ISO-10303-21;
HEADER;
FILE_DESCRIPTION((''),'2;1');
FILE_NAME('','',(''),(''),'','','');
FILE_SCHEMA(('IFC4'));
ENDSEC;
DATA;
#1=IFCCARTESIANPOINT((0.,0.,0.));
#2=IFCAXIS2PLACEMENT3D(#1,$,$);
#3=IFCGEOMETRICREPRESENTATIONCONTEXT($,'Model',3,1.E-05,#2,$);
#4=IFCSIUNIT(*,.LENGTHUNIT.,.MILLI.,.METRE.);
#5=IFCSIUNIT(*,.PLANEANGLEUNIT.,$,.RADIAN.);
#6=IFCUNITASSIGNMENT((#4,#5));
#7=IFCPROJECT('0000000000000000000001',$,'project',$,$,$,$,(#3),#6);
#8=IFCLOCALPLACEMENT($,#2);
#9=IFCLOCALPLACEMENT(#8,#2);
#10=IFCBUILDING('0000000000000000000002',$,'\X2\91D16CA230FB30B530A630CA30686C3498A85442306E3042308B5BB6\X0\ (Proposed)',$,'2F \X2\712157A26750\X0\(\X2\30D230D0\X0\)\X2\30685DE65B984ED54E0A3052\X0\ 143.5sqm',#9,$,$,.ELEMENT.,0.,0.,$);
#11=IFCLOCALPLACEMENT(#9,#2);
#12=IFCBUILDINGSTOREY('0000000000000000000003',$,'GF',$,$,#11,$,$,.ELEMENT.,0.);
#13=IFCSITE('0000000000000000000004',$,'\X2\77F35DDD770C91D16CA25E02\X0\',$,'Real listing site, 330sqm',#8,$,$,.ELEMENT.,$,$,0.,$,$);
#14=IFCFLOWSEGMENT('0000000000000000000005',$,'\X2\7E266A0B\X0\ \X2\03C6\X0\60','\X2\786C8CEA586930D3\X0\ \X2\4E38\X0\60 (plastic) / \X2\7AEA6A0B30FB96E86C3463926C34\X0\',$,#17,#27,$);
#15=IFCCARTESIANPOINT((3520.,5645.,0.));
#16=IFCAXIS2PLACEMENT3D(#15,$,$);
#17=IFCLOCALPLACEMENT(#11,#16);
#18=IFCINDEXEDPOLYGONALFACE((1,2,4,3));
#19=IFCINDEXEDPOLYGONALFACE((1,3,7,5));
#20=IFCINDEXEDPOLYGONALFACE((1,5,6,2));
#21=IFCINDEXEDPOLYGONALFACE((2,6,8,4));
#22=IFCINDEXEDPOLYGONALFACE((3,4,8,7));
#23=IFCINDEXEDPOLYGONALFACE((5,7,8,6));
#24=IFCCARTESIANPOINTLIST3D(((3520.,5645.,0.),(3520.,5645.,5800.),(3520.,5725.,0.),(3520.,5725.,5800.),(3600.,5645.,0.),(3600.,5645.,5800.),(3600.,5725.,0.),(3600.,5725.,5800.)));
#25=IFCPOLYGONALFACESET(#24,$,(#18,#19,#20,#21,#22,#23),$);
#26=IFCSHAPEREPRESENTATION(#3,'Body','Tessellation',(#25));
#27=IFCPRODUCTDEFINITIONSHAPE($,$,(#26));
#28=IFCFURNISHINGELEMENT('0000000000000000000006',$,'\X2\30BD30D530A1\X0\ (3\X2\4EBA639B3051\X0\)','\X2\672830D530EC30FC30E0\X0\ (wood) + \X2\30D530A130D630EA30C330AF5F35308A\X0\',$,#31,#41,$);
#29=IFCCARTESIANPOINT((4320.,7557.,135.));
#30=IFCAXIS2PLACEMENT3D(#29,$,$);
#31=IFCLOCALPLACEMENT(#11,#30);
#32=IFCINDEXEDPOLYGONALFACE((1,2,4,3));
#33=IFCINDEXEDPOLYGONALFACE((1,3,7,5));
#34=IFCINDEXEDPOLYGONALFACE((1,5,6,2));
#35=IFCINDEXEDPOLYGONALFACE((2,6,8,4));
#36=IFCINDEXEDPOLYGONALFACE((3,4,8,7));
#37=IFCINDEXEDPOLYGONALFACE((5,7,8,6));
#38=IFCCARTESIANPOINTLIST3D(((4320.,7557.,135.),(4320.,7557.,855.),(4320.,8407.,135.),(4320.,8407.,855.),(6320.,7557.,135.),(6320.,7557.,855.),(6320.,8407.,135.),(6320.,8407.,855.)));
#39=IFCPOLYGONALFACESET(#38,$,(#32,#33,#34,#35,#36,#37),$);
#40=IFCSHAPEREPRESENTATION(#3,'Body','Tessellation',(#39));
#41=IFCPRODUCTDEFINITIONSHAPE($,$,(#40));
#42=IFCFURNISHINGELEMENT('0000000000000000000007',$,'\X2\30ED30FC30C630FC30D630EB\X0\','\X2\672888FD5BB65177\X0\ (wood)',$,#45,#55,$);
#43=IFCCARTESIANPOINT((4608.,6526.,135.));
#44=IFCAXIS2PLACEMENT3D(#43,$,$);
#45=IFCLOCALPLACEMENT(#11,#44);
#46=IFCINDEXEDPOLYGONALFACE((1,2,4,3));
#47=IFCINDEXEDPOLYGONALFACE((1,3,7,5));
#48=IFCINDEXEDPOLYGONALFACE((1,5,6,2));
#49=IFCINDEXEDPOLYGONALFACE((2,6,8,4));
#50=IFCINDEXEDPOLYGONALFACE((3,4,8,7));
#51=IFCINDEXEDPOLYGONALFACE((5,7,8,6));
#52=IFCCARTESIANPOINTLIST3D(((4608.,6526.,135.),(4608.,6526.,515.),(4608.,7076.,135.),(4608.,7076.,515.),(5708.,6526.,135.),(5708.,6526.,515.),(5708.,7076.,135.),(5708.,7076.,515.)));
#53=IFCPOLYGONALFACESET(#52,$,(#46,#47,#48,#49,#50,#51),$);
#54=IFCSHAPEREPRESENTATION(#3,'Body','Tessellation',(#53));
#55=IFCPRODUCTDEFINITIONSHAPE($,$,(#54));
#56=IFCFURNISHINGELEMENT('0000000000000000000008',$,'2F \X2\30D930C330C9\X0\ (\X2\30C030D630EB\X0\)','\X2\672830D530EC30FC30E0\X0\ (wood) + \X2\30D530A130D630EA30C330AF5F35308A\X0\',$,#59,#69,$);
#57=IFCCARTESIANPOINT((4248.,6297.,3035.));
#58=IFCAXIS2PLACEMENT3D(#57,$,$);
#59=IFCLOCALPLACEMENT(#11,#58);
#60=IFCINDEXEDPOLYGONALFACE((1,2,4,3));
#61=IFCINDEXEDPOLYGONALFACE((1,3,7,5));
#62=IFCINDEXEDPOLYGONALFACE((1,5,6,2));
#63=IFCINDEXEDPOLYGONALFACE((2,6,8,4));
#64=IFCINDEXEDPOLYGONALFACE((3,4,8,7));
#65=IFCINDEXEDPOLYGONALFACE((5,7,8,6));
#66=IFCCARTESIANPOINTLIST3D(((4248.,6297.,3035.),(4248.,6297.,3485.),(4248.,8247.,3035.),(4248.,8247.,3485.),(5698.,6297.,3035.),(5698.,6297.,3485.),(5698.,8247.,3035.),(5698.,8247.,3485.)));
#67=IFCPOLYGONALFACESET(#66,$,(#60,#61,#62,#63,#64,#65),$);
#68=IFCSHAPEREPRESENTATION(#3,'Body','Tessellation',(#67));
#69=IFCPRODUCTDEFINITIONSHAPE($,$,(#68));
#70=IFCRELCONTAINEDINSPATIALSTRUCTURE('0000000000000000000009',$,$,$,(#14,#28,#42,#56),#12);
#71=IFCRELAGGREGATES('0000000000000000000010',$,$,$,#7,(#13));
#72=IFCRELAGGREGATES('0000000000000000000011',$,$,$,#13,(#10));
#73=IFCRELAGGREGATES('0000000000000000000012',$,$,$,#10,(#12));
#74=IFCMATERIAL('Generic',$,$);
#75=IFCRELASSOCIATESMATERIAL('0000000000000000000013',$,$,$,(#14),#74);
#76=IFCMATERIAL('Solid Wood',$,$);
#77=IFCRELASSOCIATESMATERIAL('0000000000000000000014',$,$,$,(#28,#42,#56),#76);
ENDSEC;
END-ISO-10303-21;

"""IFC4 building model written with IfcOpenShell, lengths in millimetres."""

from ifc_helpers import new_model, si_unit, frame, frame_2d, origin, place, context, project, spatial, rectangle, extrude, material, element, save


model = new_model("IFC4")

# Units and contexts
model_context = context("Model", 3, precision=1e-05, world=origin())
ifc_project = project(units=[si_unit("LENGTHUNIT", "METRE", prefix="MILLI"), si_unit("PLANEANGLEUNIT", "RADIAN")], contexts=[model_context])

# Site, building, storey
site_placement = place(None, origin())
site = spatial("IfcSite", under=ifc_project, at=site_placement, Name="石川県金沢市", ObjectType="Real listing site, 330sqm", CompositionType="ELEMENT", RefElevation=0.0)
building_placement = place(site_placement, origin())
building = spatial("IfcBuilding", under=site, at=building_placement, Name="金沢・サウナと水風呂のある家 (Proposed)", ObjectType="2F 無垢材(ヒバ)と左官仕上げ 143.5sqm", CompositionType="ELEMENT", ElevationOfRefHeight=0.0, ElevationOfTerrain=0.0)
storey_placement = place(building_placement, origin())
storey = spatial("IfcBuildingStorey", under=building, at=storey_placement, Name="GF", CompositionType="ELEMENT", Elevation=0.0)

# Shared definitions
ifc_material_1 = material(Name="Solid Wood")

# Shared definitions
ifc_material_2 = material(Name="Generic")

# Flow segment
flow_segment_1_placement = place(storey_placement, frame((3520.0, 5645.0, 0.0)))
element("IfcFlowSegment", 1, at=flow_segment_1_placement, inside=storey, material=ifc_material_2, Name="縦樋 φ60", Description="硬質塩ビ 丸60 (plastic) / 竪樋・雨水排水", context=model_context, shape_type="SweptSolid", body=[
    extrude(rectangle(XDim=80.0, YDim=80.0, at=frame_2d((40.0, 40.0))), frame((3520.0, 5645.0, 0.0)), (0.0, 0.0, 1.0), 5800.0),
])

# Furnishing elements
furnishing_1_placement = place(storey_placement, frame((4320.0, 7557.0, 135.0)))
element("IfcFurnishingElement", 2, at=furnishing_1_placement, inside=storey, material=ifc_material_1, Name="ソファ (3人掛け)", Description="木フレーム (wood) + ファブリック張り", context=model_context, shape_type="SweptSolid", body=[
    extrude(rectangle(XDim=2000.0, YDim=850.0, at=frame_2d((1000.0, 425.0))), frame((4320.0, 7557.0, 135.0)), (0.0, 0.0, 1.0), 720.0),
])
furnishing_2_placement = place(storey_placement, frame((4608.0, 6526.0, 135.0)))
element("IfcFurnishingElement", 3, at=furnishing_2_placement, inside=storey, material=ifc_material_1, Name="ローテーブル", Description="木製家具 (wood)", context=model_context, shape_type="SweptSolid", body=[
    extrude(rectangle(XDim=1100.0, YDim=550.0, at=frame_2d((550.0, 275.0))), frame((4608.0, 6526.0, 135.0)), (0.0, 0.0, 1.0), 380.0),
])
furnishing_3_placement = place(storey_placement, frame((4248.0, 6297.0, 3035.0)))
element("IfcFurnishingElement", 4, at=furnishing_3_placement, inside=storey, material=ifc_material_1, Name="2F ベッド (ダブル)", Description="木フレーム (wood) + ファブリック張り", context=model_context, shape_type="SweptSolid", body=[
    extrude(rectangle(XDim=1450.0, YDim=1950.0, at=frame_2d((725.0, 975.0))), frame((4248.0, 6297.0, 3035.0)), (0.0, 0.0, 1.0), 450.0),
])

save(model, "model.ifc")
